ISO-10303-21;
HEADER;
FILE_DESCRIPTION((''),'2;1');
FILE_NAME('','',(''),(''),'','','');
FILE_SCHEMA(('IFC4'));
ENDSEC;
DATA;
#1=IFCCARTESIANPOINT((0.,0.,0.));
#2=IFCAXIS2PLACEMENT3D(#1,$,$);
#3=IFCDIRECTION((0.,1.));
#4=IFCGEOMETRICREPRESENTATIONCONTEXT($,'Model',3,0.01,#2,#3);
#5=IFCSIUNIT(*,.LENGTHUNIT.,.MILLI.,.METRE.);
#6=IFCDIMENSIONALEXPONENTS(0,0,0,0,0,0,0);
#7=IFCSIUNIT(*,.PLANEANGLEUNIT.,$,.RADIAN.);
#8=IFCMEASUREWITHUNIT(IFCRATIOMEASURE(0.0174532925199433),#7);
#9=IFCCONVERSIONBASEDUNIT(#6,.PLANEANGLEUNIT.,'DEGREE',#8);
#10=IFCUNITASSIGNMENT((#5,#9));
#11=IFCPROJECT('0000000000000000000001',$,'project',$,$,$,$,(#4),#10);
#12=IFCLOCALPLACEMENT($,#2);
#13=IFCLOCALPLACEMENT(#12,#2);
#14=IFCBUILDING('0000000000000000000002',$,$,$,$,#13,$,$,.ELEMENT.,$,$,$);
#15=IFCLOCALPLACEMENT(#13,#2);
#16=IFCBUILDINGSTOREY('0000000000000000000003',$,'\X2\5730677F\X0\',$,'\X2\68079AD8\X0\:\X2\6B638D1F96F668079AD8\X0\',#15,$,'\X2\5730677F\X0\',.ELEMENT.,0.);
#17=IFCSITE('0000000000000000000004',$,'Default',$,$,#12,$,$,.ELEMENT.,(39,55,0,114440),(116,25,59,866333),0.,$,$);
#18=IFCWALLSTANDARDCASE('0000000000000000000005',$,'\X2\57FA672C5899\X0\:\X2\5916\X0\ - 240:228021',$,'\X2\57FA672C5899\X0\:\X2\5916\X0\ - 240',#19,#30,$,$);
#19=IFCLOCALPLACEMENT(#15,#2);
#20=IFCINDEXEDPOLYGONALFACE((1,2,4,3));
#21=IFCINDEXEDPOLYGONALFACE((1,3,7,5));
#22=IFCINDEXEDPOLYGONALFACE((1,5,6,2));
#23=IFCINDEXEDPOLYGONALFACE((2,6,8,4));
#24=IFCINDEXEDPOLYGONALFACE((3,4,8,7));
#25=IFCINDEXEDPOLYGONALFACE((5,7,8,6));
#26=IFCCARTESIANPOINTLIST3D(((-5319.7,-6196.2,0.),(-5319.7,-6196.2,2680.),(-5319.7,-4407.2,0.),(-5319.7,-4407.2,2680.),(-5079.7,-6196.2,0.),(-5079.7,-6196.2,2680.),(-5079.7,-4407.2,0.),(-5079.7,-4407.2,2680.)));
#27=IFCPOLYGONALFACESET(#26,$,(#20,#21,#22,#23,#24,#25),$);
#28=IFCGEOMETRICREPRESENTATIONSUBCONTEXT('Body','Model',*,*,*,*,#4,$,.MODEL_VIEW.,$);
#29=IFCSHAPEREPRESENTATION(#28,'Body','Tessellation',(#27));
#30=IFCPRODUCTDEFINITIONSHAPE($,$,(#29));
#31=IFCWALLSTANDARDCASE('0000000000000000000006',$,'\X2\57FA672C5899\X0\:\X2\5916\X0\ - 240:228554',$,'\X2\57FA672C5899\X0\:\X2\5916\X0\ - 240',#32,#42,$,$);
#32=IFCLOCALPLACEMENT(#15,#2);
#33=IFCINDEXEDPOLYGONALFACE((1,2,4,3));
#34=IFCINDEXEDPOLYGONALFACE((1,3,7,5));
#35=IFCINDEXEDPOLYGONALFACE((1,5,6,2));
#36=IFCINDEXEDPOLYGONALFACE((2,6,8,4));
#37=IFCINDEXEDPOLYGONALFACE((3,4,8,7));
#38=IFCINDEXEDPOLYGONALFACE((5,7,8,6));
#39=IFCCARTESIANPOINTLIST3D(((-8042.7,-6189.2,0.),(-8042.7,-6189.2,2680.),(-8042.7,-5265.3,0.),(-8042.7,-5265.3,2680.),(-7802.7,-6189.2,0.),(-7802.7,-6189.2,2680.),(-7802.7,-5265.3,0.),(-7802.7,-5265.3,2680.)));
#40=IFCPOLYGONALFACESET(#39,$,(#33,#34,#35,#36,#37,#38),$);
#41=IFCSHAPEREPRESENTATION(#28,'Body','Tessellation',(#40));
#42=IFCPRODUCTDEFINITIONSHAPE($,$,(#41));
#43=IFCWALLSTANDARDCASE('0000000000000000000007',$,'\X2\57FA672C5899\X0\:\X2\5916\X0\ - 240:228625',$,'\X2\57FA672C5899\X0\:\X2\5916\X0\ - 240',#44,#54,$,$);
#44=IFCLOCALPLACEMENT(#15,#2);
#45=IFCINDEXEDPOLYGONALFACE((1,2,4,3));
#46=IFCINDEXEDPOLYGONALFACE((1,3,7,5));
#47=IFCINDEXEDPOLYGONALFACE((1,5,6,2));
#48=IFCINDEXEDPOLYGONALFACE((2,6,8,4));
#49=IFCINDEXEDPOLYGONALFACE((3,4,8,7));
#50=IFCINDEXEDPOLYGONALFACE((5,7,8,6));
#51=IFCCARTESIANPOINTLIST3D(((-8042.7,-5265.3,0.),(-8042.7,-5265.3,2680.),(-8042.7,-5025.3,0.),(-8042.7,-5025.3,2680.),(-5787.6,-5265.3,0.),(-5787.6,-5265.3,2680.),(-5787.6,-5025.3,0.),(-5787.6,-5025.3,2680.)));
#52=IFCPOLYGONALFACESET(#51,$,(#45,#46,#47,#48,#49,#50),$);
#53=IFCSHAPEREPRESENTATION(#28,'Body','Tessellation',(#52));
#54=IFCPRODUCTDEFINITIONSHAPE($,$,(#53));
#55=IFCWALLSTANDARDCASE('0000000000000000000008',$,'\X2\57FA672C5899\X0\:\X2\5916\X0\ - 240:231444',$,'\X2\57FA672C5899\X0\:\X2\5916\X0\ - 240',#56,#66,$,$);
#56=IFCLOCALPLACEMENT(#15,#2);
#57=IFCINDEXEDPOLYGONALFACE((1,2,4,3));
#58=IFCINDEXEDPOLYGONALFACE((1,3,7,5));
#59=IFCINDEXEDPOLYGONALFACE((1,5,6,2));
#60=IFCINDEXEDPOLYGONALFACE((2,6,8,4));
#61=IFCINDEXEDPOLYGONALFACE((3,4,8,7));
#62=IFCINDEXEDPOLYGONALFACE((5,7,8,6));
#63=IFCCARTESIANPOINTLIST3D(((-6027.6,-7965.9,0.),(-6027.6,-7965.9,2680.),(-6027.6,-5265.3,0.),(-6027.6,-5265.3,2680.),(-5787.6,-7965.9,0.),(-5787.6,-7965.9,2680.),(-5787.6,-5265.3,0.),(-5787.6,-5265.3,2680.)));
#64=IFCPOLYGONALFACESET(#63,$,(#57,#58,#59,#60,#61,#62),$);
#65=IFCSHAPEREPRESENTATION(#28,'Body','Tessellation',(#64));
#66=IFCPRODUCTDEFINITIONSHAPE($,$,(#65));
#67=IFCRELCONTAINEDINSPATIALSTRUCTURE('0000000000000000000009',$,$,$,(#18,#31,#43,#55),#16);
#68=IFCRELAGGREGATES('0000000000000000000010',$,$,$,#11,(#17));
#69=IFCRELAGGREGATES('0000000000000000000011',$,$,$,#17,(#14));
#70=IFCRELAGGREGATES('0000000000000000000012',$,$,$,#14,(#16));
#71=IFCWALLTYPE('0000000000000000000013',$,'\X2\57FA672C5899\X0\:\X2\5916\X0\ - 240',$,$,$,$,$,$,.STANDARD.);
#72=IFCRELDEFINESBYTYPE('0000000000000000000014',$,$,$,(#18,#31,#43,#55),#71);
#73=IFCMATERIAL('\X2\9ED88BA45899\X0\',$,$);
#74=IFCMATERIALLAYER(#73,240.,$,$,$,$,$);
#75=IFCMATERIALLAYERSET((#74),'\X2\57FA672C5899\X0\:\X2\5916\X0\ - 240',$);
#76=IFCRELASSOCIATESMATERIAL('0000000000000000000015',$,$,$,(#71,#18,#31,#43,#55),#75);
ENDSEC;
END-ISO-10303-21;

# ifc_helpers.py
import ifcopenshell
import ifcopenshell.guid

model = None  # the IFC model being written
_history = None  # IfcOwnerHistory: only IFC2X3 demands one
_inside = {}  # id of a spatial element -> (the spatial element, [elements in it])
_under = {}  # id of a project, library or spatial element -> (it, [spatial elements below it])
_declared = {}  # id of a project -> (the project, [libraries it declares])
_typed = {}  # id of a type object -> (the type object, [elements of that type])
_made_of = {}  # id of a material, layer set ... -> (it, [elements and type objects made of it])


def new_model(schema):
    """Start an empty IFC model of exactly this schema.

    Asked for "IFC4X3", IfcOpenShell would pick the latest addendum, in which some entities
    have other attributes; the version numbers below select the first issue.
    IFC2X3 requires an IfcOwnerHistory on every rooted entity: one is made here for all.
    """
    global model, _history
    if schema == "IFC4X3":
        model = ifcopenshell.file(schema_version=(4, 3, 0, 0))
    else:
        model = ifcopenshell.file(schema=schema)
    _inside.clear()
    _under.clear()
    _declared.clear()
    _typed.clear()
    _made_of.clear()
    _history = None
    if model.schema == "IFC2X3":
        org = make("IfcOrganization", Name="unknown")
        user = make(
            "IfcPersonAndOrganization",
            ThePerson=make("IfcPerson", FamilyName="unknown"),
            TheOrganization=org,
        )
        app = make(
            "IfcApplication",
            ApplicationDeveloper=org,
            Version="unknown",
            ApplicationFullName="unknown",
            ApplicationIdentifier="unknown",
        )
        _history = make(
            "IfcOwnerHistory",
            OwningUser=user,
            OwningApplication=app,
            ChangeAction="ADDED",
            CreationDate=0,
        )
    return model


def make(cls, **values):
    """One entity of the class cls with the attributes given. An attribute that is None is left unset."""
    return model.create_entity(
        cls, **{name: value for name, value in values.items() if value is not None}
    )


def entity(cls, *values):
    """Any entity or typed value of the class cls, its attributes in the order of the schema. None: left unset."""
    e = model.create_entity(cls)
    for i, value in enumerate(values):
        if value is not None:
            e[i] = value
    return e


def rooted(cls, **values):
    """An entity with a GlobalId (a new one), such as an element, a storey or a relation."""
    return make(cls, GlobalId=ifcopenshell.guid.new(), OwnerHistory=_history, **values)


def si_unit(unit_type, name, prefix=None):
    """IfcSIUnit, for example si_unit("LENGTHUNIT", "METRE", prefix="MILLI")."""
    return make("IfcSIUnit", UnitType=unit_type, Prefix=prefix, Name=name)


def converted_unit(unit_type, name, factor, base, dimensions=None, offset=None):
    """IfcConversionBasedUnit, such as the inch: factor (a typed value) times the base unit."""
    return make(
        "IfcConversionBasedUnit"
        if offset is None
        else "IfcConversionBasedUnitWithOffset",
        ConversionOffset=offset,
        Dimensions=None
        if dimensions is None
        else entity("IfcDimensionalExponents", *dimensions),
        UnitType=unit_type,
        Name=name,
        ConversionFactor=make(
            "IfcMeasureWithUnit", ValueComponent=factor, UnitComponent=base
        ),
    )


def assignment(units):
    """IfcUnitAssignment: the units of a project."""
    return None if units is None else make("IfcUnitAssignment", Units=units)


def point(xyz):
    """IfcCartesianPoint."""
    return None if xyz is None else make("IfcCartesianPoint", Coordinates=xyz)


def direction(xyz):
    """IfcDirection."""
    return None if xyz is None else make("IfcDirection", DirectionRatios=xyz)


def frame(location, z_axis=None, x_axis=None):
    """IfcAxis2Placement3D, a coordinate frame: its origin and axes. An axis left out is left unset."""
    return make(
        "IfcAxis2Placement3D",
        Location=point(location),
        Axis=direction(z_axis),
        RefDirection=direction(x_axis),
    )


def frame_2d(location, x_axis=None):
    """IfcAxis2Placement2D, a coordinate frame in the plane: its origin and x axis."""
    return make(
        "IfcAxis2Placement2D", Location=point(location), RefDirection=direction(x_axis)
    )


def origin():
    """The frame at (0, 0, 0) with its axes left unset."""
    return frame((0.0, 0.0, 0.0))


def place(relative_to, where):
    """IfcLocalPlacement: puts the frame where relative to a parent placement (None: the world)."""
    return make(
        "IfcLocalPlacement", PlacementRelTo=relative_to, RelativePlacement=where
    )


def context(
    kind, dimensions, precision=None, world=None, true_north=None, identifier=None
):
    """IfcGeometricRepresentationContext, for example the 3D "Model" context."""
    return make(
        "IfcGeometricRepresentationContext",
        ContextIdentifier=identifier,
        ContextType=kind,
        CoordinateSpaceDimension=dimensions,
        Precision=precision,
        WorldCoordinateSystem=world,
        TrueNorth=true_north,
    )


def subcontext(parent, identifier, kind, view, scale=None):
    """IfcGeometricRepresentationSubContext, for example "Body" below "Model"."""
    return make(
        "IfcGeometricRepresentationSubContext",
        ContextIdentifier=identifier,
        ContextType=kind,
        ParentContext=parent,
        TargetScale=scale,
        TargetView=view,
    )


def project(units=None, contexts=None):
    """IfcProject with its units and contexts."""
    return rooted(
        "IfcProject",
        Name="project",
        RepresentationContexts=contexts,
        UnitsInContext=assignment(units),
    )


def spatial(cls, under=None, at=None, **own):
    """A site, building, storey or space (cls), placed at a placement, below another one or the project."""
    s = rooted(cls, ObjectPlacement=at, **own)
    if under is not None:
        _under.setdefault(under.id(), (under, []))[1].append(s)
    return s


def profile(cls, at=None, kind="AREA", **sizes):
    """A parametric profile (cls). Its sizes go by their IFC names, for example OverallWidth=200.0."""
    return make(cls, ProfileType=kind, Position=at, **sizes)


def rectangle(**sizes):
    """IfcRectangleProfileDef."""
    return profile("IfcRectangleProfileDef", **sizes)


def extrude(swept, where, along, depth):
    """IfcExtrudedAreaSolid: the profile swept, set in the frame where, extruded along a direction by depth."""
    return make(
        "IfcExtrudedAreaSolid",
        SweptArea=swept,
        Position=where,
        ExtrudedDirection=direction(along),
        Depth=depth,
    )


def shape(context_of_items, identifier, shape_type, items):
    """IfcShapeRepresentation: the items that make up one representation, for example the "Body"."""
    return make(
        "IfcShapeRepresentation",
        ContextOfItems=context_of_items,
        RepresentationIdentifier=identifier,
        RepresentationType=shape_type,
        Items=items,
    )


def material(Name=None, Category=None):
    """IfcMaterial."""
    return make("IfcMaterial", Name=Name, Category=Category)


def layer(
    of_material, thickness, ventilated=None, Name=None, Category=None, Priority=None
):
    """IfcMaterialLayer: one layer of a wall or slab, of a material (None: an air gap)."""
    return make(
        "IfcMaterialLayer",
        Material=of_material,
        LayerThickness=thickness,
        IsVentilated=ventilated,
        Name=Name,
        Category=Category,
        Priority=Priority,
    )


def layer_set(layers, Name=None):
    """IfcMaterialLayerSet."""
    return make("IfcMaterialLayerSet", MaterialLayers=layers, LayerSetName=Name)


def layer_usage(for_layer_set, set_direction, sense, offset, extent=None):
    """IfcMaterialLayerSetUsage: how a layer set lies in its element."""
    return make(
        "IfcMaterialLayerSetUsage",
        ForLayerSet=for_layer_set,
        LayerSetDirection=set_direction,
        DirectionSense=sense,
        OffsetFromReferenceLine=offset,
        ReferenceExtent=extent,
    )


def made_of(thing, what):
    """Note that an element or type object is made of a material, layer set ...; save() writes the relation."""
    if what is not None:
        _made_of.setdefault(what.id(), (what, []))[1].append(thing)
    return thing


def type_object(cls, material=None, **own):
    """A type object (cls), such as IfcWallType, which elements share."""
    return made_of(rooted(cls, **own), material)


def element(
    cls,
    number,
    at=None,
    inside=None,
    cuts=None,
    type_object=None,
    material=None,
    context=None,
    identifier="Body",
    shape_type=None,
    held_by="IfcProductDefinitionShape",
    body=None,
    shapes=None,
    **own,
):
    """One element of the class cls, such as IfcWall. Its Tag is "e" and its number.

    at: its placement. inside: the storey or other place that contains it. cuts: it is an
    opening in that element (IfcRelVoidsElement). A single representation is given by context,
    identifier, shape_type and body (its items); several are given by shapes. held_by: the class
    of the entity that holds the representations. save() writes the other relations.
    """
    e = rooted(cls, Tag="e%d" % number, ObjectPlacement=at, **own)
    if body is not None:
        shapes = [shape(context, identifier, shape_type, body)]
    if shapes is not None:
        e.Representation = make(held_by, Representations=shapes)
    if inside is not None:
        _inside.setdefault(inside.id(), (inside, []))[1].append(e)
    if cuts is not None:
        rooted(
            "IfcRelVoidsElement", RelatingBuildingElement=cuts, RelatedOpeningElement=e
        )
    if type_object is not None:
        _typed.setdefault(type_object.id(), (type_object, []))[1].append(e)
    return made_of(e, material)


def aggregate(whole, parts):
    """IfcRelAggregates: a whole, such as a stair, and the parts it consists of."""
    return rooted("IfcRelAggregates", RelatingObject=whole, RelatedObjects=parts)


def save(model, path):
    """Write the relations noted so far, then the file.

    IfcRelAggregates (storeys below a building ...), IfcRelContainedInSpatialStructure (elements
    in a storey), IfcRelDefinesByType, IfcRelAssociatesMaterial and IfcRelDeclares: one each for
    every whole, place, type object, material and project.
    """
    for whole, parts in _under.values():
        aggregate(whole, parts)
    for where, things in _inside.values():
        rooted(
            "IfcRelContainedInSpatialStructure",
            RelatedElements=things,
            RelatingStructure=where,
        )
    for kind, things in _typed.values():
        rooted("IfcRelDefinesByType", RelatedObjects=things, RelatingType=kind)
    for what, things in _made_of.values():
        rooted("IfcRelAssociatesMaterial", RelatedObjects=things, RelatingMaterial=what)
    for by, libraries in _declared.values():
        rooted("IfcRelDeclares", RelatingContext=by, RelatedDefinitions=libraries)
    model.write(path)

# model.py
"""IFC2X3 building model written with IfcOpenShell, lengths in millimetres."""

from ifc_helpers import new_model, entity, si_unit, converted_unit, direction, frame, frame_2d, origin, place, context, subcontext, project, spatial, rectangle, extrude, material, layer, layer_set, layer_usage, type_object, element, save


model = new_model("IFC2X3")

# Units and contexts
model_context = context("Model", 3, precision=0.01, world=origin(), true_north=direction((0.0, 1.0)))
body_context = subcontext(model_context, "Body", "Model", "MODEL_VIEW")
ifc_project = project(units=[si_unit("LENGTHUNIT", "METRE", prefix="MILLI"), converted_unit("PLANEANGLEUNIT", "DEGREE", entity("IfcRatioMeasure", 0.0174532925199433), si_unit("PLANEANGLEUNIT", "RADIAN"), dimensions=[0, 0, 0, 0, 0, 0, 0])], contexts=[model_context])

# Site, building, storey
site_placement = place(None, origin())
site = spatial("IfcSite", under=ifc_project, at=site_placement, Name="Default", CompositionType="ELEMENT", RefLatitude=(39, 55, 0, 114440), RefLongitude=(116, 25, 59, 866333), RefElevation=0.0)
building_placement = place(site_placement, origin())
building = spatial("IfcBuilding", under=site, at=building_placement, CompositionType="ELEMENT")
storey_placement = place(building_placement, origin())
storey = spatial("IfcBuildingStorey", under=building, at=storey_placement, Name="地板", ObjectType="标高:正负零标高", LongName="地板", CompositionType="ELEMENT", Elevation=0.0)

# Shared definitions
ifc_material_1 = material(Name="默认墙")
ifc_layer = layer(ifc_material_1, 240.0)
ifc_layer_set = layer_set([ifc_layer], Name="基本墙:外 - 240")
wall_type = type_object("IfcWallType", Name="基本墙:外 - 240", PredefinedType="STANDARD", material=ifc_layer_set)

# Wall
ifc_layer_usage_1 = layer_usage(ifc_layer_set, "AXIS2", "NEGATIVE", 120.0)
wall_1_placement = place(storey_placement, frame((-5199.7, -4407.2, 0.0), z_axis=(0.0, 0.0, 1.0), x_axis=(0.0, -1.0, 0.0)))
element("IfcWallStandardCase", 1, at=wall_1_placement, inside=storey, type_object=wall_type, material=ifc_layer_usage_1, Name="基本墙:外 - 240:228021", ObjectType="基本墙:外 - 240", context=body_context, shape_type="SweptSolid", body=[
    extrude(rectangle(XDim=1789.0, YDim=240.0, at=frame_2d((894.5, 0.0), x_axis=(-1.0, 0.0))), origin(), (0.0, 0.0, 1.0), 2680.0),
])

# Walls
ifc_layer_usage_2 = layer_usage(ifc_layer_set, "AXIS2", "NEGATIVE", 120.0)
wall_2_placement = place(storey_placement, frame((-7922.7, -5265.3, 0.0), z_axis=(0.0, 0.0, 1.0), x_axis=(0.0, -1.0, 0.0)))
element("IfcWallStandardCase", 2, at=wall_2_placement, inside=storey, type_object=wall_type, material=ifc_layer_usage_2, Name="基本墙:外 - 240:228554", ObjectType="基本墙:外 - 240", context=body_context, shape_type="SweptSolid", body=[
    extrude(rectangle(XDim=923.9, YDim=240.0, at=frame_2d((461.9, 0.0), x_axis=(-1.0, 0.0))), origin(), (0.0, 0.0, 1.0), 2680.0),
])
ifc_layer_usage_3 = layer_usage(ifc_layer_set, "AXIS2", "NEGATIVE", 120.0)
wall_3_placement = place(storey_placement, frame((-8042.7, -5145.3, 0.0)))
element("IfcWallStandardCase", 3, at=wall_3_placement, inside=storey, type_object=wall_type, material=ifc_layer_usage_3, Name="基本墙:外 - 240:228625", ObjectType="基本墙:外 - 240", context=body_context, shape_type="SweptSolid", body=[
    extrude(rectangle(XDim=2255.1, YDim=240.0, at=frame_2d((1127.5, 0.0), x_axis=(-1.0, 0.0))), origin(), (0.0, 0.0, 1.0), 2680.0),
])
ifc_layer_usage_4 = layer_usage(ifc_layer_set, "AXIS2", "NEGATIVE", 120.0)
wall_4_placement = place(storey_placement, frame((-5907.6, -5265.3, 0.0), z_axis=(0.0, 0.0, 1.0), x_axis=(0.0, -1.0, 0.0)))
element("IfcWallStandardCase", 4, at=wall_4_placement, inside=storey, type_object=wall_type, material=ifc_layer_usage_4, Name="基本墙:外 - 240:231444", ObjectType="基本墙:外 - 240", context=body_context, shape_type="SweptSolid", body=[
    extrude(rectangle(XDim=2700.5, YDim=240.0, at=frame_2d((1350.3, 0.0), x_axis=(-1.0, 0.0))), origin(), (0.0, 0.0, 1.0), 2680.0),
])

save(model, "model.ifc")
